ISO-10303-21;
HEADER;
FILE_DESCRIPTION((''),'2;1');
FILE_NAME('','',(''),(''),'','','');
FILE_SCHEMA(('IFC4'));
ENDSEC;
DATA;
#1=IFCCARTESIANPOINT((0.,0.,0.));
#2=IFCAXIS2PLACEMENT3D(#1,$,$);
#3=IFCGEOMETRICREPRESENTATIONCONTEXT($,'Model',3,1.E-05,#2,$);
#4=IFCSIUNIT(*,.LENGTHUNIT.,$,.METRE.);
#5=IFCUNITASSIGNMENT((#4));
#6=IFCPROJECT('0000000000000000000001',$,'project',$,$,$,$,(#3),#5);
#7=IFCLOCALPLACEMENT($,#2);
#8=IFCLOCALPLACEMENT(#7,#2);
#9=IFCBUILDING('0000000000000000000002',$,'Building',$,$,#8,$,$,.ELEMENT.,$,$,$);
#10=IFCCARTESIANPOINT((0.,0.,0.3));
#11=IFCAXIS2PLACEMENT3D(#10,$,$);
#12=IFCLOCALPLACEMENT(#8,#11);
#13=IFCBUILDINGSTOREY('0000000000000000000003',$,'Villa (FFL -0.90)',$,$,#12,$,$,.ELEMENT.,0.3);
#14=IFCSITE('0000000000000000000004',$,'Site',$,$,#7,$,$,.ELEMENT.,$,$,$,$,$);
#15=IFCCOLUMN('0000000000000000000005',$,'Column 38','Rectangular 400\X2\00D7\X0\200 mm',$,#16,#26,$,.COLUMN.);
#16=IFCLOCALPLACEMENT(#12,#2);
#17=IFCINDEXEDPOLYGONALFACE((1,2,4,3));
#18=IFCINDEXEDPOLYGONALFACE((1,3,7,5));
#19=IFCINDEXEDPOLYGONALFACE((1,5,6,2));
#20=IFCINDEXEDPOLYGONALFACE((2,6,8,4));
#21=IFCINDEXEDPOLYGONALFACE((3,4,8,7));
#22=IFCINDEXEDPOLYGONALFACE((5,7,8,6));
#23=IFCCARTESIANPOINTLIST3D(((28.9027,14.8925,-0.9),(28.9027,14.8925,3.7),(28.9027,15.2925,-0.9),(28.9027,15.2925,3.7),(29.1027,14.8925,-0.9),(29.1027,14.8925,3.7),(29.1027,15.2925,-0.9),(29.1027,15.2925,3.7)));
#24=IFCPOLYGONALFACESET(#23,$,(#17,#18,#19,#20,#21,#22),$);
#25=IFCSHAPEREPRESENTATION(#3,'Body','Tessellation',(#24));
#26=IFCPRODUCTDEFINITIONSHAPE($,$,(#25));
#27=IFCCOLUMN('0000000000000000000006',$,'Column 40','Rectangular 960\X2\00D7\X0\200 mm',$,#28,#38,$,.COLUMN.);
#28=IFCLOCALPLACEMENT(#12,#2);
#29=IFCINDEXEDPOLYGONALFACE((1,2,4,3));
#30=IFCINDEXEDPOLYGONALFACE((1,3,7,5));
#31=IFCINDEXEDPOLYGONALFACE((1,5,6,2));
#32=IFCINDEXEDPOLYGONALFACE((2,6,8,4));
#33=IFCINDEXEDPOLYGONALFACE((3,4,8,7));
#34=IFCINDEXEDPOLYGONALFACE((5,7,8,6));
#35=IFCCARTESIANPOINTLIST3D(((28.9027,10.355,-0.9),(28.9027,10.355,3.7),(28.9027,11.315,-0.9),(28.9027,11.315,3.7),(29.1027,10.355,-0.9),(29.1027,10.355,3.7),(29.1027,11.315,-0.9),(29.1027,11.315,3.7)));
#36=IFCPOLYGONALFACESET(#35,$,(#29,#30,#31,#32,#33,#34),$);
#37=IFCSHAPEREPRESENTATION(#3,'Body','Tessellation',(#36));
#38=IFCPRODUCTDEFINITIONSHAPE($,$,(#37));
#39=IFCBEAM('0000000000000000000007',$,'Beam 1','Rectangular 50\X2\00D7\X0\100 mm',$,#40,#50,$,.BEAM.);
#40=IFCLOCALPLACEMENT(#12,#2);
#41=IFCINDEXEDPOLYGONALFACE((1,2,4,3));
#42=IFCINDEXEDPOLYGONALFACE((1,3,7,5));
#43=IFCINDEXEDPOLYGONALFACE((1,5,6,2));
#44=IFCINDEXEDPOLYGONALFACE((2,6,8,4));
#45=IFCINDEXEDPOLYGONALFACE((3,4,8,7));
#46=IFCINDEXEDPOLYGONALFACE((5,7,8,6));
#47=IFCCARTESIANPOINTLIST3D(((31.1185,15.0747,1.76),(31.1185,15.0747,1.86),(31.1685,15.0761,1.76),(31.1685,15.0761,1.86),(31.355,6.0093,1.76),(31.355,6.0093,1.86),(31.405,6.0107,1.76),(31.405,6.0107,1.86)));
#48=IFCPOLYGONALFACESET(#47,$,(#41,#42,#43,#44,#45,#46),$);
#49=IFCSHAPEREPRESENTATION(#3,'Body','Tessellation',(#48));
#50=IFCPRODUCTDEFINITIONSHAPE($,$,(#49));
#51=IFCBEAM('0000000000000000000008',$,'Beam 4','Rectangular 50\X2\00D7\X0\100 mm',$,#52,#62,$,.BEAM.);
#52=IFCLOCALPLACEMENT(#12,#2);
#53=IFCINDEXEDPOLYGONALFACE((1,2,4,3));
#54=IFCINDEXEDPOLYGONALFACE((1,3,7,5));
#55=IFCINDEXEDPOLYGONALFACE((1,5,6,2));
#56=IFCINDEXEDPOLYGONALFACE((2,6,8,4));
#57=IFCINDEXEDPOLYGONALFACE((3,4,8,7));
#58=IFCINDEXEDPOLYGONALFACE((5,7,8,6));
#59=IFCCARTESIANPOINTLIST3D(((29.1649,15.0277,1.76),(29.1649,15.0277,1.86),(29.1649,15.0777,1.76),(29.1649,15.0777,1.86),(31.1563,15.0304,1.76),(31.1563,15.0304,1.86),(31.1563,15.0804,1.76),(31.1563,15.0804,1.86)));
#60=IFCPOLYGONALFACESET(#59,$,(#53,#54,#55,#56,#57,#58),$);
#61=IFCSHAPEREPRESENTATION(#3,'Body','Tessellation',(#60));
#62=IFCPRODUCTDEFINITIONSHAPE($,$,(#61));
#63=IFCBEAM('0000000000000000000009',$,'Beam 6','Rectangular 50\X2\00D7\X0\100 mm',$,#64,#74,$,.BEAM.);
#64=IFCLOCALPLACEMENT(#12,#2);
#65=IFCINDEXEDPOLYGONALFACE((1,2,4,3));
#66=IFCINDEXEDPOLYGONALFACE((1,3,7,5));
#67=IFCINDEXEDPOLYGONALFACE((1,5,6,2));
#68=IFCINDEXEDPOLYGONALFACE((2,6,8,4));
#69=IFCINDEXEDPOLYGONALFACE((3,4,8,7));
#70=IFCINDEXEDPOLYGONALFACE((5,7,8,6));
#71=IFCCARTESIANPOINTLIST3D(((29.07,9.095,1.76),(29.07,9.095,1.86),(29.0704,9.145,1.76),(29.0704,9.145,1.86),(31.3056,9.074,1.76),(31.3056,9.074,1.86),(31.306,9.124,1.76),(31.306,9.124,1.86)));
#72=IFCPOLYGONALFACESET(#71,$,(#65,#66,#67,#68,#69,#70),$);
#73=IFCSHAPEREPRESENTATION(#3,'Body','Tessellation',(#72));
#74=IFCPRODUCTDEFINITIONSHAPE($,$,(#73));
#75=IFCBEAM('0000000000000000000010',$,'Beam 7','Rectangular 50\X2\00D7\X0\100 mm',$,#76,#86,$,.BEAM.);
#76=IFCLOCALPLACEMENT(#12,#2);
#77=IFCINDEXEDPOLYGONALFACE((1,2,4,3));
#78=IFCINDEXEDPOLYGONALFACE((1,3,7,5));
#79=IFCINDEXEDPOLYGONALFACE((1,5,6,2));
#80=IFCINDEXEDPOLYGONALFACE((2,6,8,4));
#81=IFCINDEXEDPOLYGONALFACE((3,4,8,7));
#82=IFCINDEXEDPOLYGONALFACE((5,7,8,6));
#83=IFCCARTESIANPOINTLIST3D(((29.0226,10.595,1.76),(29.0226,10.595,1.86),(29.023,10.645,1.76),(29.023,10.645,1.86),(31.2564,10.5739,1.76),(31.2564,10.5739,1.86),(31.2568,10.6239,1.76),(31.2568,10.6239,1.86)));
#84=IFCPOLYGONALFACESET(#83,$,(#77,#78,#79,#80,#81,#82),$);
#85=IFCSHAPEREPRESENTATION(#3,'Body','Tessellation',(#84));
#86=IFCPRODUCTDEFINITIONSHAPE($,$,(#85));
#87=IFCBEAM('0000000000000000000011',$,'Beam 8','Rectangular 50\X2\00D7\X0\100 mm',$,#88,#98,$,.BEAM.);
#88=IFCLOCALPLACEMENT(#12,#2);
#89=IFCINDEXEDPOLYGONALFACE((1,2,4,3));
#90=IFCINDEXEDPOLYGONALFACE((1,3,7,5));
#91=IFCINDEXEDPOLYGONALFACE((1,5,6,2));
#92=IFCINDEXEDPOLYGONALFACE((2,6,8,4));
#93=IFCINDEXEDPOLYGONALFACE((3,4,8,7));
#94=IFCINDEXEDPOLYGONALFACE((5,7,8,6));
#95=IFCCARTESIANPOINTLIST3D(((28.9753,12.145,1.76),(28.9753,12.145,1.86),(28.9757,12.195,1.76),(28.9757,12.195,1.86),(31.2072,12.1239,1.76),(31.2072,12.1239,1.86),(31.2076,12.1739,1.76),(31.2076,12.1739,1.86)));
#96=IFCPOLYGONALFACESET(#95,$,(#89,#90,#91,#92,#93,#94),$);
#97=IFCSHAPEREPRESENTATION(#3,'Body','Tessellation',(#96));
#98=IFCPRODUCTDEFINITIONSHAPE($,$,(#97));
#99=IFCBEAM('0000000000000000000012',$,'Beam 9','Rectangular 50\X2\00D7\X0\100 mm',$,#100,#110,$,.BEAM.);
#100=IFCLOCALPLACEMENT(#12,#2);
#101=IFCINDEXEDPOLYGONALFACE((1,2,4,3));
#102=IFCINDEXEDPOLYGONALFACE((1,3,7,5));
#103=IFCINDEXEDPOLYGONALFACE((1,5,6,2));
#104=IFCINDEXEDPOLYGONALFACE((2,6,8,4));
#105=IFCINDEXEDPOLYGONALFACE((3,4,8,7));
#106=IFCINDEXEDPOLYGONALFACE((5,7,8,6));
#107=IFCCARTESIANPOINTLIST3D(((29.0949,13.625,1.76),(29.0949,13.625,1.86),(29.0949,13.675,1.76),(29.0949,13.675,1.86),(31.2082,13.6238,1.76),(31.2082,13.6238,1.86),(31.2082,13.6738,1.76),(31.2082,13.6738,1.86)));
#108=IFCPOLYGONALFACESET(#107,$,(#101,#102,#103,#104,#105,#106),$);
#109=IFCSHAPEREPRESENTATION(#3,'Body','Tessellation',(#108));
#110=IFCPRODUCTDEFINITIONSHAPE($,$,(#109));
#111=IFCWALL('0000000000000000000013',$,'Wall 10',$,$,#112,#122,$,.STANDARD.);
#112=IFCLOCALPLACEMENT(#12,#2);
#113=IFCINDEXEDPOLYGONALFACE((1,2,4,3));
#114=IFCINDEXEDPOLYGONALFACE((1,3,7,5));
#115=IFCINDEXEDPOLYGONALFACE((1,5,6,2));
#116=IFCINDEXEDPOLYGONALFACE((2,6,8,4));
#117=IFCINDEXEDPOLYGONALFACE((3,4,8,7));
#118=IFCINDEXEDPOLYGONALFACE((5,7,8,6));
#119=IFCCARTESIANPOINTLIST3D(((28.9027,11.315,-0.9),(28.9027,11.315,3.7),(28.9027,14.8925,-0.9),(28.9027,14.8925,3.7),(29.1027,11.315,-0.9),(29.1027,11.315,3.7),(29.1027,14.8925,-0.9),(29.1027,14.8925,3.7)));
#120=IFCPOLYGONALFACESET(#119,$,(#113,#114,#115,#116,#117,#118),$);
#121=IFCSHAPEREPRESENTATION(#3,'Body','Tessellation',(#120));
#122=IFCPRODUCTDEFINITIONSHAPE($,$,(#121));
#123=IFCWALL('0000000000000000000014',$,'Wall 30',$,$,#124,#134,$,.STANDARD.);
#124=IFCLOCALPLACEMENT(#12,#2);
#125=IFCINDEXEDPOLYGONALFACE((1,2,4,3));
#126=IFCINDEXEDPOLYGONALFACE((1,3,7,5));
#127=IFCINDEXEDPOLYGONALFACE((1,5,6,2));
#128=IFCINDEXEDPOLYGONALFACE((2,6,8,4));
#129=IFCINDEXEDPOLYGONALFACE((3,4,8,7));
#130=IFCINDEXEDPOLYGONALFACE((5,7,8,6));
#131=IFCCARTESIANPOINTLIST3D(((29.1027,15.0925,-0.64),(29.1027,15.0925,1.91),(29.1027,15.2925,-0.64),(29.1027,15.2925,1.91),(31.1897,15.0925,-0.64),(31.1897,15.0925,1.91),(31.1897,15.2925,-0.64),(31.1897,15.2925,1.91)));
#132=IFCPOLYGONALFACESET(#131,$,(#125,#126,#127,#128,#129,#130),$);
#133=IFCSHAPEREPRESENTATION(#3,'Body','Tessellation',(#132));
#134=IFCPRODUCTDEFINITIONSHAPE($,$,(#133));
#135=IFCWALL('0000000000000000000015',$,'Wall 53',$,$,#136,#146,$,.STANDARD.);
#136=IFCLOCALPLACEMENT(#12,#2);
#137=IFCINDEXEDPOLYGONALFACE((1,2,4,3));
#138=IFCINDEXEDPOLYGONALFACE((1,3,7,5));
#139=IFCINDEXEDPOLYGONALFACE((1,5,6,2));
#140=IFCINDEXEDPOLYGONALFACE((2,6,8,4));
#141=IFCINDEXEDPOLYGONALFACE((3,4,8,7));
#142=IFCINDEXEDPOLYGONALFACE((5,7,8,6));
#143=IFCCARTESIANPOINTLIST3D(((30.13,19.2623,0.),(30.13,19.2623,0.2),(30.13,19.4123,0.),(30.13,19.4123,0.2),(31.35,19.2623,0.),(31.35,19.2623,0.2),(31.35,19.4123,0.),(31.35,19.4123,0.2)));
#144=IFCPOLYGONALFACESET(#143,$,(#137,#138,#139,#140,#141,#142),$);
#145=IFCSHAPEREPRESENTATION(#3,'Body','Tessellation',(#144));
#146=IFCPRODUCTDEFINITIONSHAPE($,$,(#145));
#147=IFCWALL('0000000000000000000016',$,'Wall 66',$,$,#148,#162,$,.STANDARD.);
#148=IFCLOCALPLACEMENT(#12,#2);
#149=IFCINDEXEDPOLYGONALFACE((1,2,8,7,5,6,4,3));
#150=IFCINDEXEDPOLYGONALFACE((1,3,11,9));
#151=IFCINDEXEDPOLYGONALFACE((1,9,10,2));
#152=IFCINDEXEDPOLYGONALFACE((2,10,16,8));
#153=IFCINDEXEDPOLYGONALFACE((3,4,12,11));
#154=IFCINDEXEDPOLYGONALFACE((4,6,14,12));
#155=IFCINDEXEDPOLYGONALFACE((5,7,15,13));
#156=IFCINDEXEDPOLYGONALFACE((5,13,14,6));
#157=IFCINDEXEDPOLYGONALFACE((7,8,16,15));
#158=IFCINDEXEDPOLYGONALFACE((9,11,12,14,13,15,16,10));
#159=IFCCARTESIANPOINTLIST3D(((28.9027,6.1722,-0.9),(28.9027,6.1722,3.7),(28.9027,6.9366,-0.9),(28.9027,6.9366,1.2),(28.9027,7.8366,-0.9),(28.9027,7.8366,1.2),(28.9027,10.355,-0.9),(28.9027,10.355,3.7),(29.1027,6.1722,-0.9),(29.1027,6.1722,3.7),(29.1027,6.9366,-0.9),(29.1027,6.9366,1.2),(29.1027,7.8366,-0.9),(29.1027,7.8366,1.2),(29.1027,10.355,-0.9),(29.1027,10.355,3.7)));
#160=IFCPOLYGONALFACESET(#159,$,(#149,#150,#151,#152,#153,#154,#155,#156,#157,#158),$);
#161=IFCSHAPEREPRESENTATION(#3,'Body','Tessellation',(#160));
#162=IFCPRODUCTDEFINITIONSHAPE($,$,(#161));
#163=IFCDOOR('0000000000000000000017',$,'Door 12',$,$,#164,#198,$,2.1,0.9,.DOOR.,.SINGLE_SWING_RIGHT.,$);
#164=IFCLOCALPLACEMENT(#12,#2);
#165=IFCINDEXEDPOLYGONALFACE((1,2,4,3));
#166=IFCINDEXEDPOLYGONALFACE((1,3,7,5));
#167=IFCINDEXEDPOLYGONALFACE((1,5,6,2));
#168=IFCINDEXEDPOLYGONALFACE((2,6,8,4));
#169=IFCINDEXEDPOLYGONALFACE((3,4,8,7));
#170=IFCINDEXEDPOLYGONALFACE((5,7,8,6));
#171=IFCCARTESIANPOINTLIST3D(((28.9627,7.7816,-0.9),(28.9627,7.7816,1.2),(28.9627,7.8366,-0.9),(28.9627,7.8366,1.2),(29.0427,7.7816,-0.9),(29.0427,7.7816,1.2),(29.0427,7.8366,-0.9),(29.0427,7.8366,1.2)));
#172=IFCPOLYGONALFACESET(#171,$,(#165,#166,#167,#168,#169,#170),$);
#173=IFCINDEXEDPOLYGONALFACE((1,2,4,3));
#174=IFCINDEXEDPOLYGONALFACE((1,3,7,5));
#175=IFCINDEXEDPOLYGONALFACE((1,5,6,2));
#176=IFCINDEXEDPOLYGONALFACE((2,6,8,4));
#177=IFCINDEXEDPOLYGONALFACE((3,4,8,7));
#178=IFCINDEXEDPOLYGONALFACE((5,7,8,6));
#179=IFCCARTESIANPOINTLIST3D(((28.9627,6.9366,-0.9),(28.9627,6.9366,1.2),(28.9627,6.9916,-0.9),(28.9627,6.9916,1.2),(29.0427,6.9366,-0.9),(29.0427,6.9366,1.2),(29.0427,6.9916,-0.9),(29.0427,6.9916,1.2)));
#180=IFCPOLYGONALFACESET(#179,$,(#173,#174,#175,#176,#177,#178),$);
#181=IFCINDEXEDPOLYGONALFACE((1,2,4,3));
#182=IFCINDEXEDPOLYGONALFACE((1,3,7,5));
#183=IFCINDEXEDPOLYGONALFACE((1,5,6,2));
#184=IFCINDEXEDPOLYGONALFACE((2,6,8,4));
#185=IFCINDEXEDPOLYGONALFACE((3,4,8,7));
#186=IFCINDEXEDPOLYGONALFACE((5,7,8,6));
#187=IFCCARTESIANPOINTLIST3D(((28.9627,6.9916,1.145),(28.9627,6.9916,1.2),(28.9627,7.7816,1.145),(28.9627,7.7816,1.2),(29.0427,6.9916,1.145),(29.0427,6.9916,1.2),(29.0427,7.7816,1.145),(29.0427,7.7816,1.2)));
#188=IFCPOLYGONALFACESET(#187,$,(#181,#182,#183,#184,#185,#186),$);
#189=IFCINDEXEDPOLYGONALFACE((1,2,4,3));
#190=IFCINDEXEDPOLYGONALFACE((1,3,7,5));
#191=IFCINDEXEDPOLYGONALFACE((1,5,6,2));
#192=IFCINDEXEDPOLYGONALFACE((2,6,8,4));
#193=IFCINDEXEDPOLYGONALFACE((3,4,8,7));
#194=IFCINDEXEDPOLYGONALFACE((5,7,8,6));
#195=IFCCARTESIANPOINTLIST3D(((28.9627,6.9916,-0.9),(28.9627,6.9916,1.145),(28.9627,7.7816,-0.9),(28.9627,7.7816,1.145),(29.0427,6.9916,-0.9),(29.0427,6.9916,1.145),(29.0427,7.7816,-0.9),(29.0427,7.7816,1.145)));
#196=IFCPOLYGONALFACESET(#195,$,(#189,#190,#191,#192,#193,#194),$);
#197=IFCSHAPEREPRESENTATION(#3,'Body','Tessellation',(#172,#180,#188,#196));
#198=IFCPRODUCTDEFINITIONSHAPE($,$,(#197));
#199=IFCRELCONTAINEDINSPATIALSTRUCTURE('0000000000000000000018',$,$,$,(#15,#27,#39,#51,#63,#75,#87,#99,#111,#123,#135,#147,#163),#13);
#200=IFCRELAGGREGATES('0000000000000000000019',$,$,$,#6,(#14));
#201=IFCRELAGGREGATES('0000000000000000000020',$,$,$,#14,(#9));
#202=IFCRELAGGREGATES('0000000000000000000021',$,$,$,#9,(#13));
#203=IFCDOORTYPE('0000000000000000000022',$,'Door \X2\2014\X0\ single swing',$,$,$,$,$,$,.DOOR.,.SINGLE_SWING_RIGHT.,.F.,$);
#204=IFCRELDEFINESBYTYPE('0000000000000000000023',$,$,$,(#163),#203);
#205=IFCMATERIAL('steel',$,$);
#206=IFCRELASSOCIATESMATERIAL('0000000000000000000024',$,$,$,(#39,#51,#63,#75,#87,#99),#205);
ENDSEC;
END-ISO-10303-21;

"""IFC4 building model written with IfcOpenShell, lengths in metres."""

from ifc_helpers import new_model, si_unit, frame, frame_2d, origin, place, context, project, spatial, polyline, rectangle, outline, extrude, material, type_object, element, fill, save


model = new_model("IFC4")

# Units and contexts
model_context = context("Model", 3, precision=1e-05, world=origin())
ifc_project = project(units=[si_unit("LENGTHUNIT", "METRE")], contexts=[model_context])

# Site, building, storey
site_placement = place(None, origin())
site = spatial("IfcSite", under=ifc_project, at=site_placement, Name="Site", CompositionType="ELEMENT")
building_placement = place(site_placement, origin())
building = spatial("IfcBuilding", under=site, at=building_placement, Name="Building", CompositionType="ELEMENT")
storey_placement = place(building_placement, frame((0.0, 0.0, 0.3)))
storey = spatial("IfcBuildingStorey", under=building, at=storey_placement, Name="Villa (FFL -0.90)", CompositionType="ELEMENT", Elevation=0.3)

# Columns
column_1_placement = place(storey_placement, frame((29.0027, 15.0925, -0.9), z_axis=(0.0, 0.0, 1.0), x_axis=(0.0, 1.0, 0.0)))
element("IfcColumn", 1, at=column_1_placement, inside=storey, Name="Column 38", Description="Rectangular 400×200 mm", PredefinedType="COLUMN", context=model_context, shape_type="SweptSolid", body=[
    extrude(outline(polyline([(-0.2, -0.1), (0.2, -0.1), (0.2, 0.1), (-0.2, 0.1), (-0.2, -0.1)])), origin(), (0.0, 0.0, 1.0), 4.6),
])
column_2_placement = place(storey_placement, frame((29.0027, 10.835, -0.9), z_axis=(0.0, 0.0, 1.0), x_axis=(0.0, 1.0, 0.0)))
element("IfcColumn", 2, at=column_2_placement, inside=storey, Name="Column 40", Description="Rectangular 960×200 mm", PredefinedType="COLUMN", context=model_context, shape_type="SweptSolid", body=[
    extrude(outline(polyline([(-0.48, -0.1), (0.48, -0.1), (0.48, 0.1), (-0.48, 0.1), (-0.48, -0.1)])), origin(), (0.0, 0.0, 1.0), 4.6),
])

# Beams
ifc_material = material(Name="steel")
beam_1_placement = place(storey_placement, frame((31.1435, 15.0754, 1.81), z_axis=(0.026079, -0.99966, 0.0), x_axis=(0.99966, 0.026079, 0.0)))
element("IfcBeam", 3, at=beam_1_placement, inside=storey, material=ifc_material, Name="Beam 1", Description="Rectangular 50×100 mm", PredefinedType="BEAM", context=model_context, shape_type="SweptSolid", body=[
    extrude(outline(polyline([(-0.025, -0.05), (0.025, -0.05), (0.025, 0.05), (-0.025, 0.05), (-0.025, -0.05)])), origin(), (0.0, 0.0, 1.0), 9.0685),
])
beam_2_placement = place(storey_placement, frame((29.1649, 15.0527, 1.81), z_axis=(0.999999, 0.001356, 0.0), x_axis=(-0.001356, 0.999999, 0.0)))
element("IfcBeam", 4, at=beam_2_placement, inside=storey, material=ifc_material, Name="Beam 4", Description="Rectangular 50×100 mm", PredefinedType="BEAM", context=model_context, shape_type="SweptSolid", body=[
    extrude(outline(polyline([(-0.025, -0.05), (0.025, -0.05), (0.025, 0.05), (-0.025, 0.05), (-0.025, -0.05)])), origin(), (0.0, 0.0, 1.0), 1.9914),
])
beam_3_placement = place(storey_placement, frame((29.0702, 9.12, 1.81), z_axis=(0.999956, -0.009393, 0.0), x_axis=(0.009393, 0.999956, 0.0)))
element("IfcBeam", 5, at=beam_3_placement, inside=storey, material=ifc_material, Name="Beam 6", Description="Rectangular 50×100 mm", PredefinedType="BEAM", context=model_context, shape_type="SweptSolid", body=[
    extrude(outline(polyline([(-0.025, -0.05), (0.025, -0.05), (0.025, 0.05), (-0.025, 0.05), (-0.025, -0.05)])), origin(), (0.0, 0.0, 1.0), 2.2357),
])
beam_4_placement = place(storey_placement, frame((29.0228, 10.62, 1.81), z_axis=(0.999955, -0.009445, 0.0), x_axis=(0.009445, 0.999955, 0.0)))
element("IfcBeam", 6, at=beam_4_placement, inside=storey, material=ifc_material, Name="Beam 7", Description="Rectangular 50×100 mm", PredefinedType="BEAM", context=model_context, shape_type="SweptSolid", body=[
    extrude(outline(polyline([(-0.025, -0.05), (0.025, -0.05), (0.025, 0.05), (-0.025, 0.05), (-0.025, -0.05)])), origin(), (0.0, 0.0, 1.0), 2.2339),
])
beam_5_placement = place(storey_placement, frame((28.9755, 12.17, 1.81), z_axis=(0.999955, -0.009453, 0.0), x_axis=(0.009453, 0.999955, 0.0)))
element("IfcBeam", 7, at=beam_5_placement, inside=storey, material=ifc_material, Name="Beam 8", Description="Rectangular 50×100 mm", PredefinedType="BEAM", context=model_context, shape_type="SweptSolid", body=[
    extrude(outline(polyline([(-0.025, -0.05), (0.025, -0.05), (0.025, 0.05), (-0.025, 0.05), (-0.025, -0.05)])), origin(), (0.0, 0.0, 1.0), 2.232),
])
beam_6_placement = place(storey_placement, frame((29.0949, 13.65, 1.81), z_axis=(1.0, -0.000568, 0.0), x_axis=(0.000568, 1.0, 0.0)))
element("IfcBeam", 8, at=beam_6_placement, inside=storey, material=ifc_material, Name="Beam 9", Description="Rectangular 50×100 mm", PredefinedType="BEAM", context=model_context, shape_type="SweptSolid", body=[
    extrude(outline(polyline([(-0.025, -0.05), (0.025, -0.05), (0.025, 0.05), (-0.025, 0.05), (-0.025, -0.05)])), origin(), (0.0, 0.0, 1.0), 2.1133),
])

# Walls
wall_1_placement = place(storey_placement, frame((29.0027, 14.8925, -0.9), z_axis=(0.0, 0.0, 1.0), x_axis=(0.0, -1.0, 0.0)))
element("IfcWall", 9, at=wall_1_placement, inside=storey, Name="Wall 10", PredefinedType="STANDARD", context=model_context, shape_type="SweptSolid", body=[
    extrude(rectangle(XDim=3.5775, YDim=0.2, at=frame_2d((1.7887, 0.0))), origin(), (0.0, 0.0, 1.0), 4.6),
])
wall_2_placement = place(storey_placement, frame((29.1027, 15.1925, -0.64), z_axis=(0.0, 0.0, 1.0), x_axis=(1.0, 0.0, 0.0)))
element("IfcWall", 10, at=wall_2_placement, inside=storey, Name="Wall 30", PredefinedType="STANDARD", context=model_context, shape_type="SweptSolid", body=[
    extrude(rectangle(XDim=2.087, YDim=0.2, at=frame_2d((1.0435, 0.0))), origin(), (0.0, 0.0, 1.0), 2.55),
])
wall_3_placement = place(storey_placement, frame((31.35, 19.3373, 0.0), z_axis=(0.0, 0.0, 1.0), x_axis=(-1.0, 0.0, 0.0)))
element("IfcWall", 11, at=wall_3_placement, inside=storey, Name="Wall 53", PredefinedType="STANDARD", context=model_context, shape_type="SweptSolid", body=[
    extrude(rectangle(XDim=1.22, YDim=0.15, at=frame_2d((0.61, 0.0))), origin(), (0.0, 0.0, 1.0), 0.2),
])

# Wall, opening, door
wall_4_placement = place(storey_placement, frame((29.0027, 10.355, -0.9), z_axis=(0.0, 0.0, 1.0), x_axis=(0.0, -1.0, 0.0)))
wall_4 = element("IfcWall", 12, at=wall_4_placement, inside=storey, Name="Wall 66", PredefinedType="STANDARD", context=model_context, shape_type="SweptSolid", body=[
    extrude(rectangle(XDim=4.1829, YDim=0.2, at=frame_2d((2.0914, 0.0))), origin(), (0.0, 0.0, 1.0), 4.6),
])
opening_1_placement = place(storey_placement, frame((29.0027, 7.8366, -0.9), z_axis=(0.0, 0.0, 1.0), x_axis=(0.0, -1.0, 0.0)))
opening_1 = element("IfcOpeningElement", 13, at=opening_1_placement, cuts=wall_4, PredefinedType="OPENING", context=model_context, shape_type="SweptSolid", body=[
    extrude(rectangle(XDim=0.9, YDim=0.26, at=frame_2d((0.45, 0.0))), origin(), (0.0, 0.0, 1.0), 2.1),
])
door_type_1 = type_object("IfcDoorType", Name="Door — single swing", OperationType="SINGLE_SWING_RIGHT", ParameterTakesPrecedence=False, PredefinedType="DOOR")
door_1_placement = place(storey_placement, frame((29.0027, 7.8366, -0.9), z_axis=(0.0, 0.0, 1.0), x_axis=(0.0, -1.0, 0.0)))
door_1 = element("IfcDoor", 14, at=door_1_placement, inside=storey, type_object=door_type_1, Name="Door 12", OperationType="SINGLE_SWING_RIGHT", OverallHeight=2.1, OverallWidth=0.9, PredefinedType="DOOR", context=model_context, shape_type="SweptSolid", body=[
    extrude(rectangle(XDim=0.055, YDim=0.08, at=frame_2d((0.0275, 0.0))), origin(), (0.0, 0.0, 1.0), 2.1),
    extrude(rectangle(XDim=0.055, YDim=0.08, at=frame_2d((0.8725, 0.0))), origin(), (0.0, 0.0, 1.0), 2.1),
    extrude(rectangle(XDim=0.79, YDim=0.08, at=frame_2d((0.45, 0.0))), frame((0.0, 0.0, 2.045)), (0.0, 0.0, 1.0), 0.055),
    extrude(rectangle(XDim=0.79, YDim=0.08, at=frame_2d((0.45, 0.0))), origin(), (0.0, 0.0, 1.0), 2.045),
])
fill(opening_1, door_1)

save(model, "model.ifc")
